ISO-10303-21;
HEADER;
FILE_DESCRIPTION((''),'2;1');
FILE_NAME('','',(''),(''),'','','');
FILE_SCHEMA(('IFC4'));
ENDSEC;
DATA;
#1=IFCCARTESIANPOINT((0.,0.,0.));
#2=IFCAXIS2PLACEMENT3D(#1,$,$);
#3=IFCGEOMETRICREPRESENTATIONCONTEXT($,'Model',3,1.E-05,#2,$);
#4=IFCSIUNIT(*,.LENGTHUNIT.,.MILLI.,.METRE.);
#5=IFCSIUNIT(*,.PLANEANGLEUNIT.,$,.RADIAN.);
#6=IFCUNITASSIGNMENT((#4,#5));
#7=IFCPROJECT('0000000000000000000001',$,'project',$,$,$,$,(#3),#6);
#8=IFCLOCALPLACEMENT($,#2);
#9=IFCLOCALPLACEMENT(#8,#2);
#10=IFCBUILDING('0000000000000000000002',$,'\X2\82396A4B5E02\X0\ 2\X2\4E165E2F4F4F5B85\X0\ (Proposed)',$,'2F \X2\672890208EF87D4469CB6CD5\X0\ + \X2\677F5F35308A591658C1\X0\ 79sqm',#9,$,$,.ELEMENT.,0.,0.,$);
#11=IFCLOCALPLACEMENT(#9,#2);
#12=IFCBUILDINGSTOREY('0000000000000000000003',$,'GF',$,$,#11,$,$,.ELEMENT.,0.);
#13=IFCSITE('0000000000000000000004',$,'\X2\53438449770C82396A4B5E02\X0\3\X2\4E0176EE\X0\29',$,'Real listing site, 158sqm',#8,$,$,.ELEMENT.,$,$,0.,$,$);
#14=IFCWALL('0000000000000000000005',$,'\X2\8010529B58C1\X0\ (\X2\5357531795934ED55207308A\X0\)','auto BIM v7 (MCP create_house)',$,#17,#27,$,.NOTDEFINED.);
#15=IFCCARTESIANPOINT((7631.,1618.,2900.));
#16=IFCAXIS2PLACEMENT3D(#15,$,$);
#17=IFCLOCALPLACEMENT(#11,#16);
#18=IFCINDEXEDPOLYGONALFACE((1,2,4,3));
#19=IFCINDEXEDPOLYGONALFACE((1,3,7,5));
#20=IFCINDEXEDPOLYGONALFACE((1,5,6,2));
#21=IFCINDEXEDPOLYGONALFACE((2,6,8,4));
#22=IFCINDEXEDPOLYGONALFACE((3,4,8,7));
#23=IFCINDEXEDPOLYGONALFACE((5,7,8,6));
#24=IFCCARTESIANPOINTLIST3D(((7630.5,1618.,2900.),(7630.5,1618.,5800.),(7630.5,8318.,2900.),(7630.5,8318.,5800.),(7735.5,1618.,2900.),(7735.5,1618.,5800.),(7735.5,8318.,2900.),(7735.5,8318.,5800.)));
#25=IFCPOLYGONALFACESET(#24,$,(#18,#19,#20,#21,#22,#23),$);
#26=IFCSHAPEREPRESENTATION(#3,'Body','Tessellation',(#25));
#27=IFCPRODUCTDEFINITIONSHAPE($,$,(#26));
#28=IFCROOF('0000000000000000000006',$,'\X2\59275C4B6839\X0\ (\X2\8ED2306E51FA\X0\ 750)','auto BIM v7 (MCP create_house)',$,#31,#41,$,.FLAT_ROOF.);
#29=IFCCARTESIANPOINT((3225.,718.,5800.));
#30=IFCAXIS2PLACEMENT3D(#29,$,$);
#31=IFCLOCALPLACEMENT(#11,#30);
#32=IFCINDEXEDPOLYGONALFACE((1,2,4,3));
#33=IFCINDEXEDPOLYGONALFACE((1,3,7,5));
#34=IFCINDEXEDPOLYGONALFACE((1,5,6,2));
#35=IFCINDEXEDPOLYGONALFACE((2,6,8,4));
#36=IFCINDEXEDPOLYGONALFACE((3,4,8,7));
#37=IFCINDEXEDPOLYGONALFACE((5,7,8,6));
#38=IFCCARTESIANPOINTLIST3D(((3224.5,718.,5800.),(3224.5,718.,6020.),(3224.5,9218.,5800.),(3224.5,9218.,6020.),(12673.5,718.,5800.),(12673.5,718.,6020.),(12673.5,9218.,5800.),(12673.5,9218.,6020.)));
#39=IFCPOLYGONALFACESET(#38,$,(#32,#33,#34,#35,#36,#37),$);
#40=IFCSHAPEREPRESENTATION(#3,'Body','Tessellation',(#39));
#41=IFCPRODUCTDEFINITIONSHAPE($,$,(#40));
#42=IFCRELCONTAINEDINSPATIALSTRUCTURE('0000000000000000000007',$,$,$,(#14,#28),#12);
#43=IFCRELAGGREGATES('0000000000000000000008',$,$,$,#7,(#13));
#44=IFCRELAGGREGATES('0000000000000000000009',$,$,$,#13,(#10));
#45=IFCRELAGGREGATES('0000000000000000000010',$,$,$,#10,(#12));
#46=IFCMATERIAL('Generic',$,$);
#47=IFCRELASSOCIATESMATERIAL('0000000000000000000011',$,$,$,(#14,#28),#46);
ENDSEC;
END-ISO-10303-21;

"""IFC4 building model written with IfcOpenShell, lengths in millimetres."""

from ifc_helpers import new_model, si_unit, frame, frame_2d, origin, place, context, project, spatial, rectangle, extrude, material, element, save


model = new_model("IFC4")

# Units and contexts
model_context = context("Model", 3, precision=1e-05, world=origin())
ifc_project = project(units=[si_unit("LENGTHUNIT", "METRE", prefix="MILLI"), si_unit("PLANEANGLEUNIT", "RADIAN")], contexts=[model_context])

# Site, building, storey
site_placement = place(None, origin())
site = spatial("IfcSite", under=ifc_project, at=site_placement, Name="千葉県船橋市3丁目29", ObjectType="Real listing site, 158sqm", CompositionType="ELEMENT", RefElevation=0.0)
building_placement = place(site_placement, origin())
building = spatial("IfcBuilding", under=site, at=building_placement, Name="船橋市 2世帯住宅 (Proposed)", ObjectType="2F 木造軸組構法 + 板張り外壁 79sqm", CompositionType="ELEMENT", ElevationOfRefHeight=0.0, ElevationOfTerrain=0.0)
storey_placement = place(building_placement, origin())
storey = spatial("IfcBuildingStorey", under=building, at=storey_placement, Name="GF", CompositionType="ELEMENT", Elevation=0.0)

# Shared definitions
ifc_material = material(Name="Generic")

# Wall
wall_1_placement = place(storey_placement, frame((7631.0, 1618.0, 2900.0)))
element("IfcWall", 1, at=wall_1_placement, inside=storey, material=ifc_material, Name="耐力壁 (南北間仕切り)", Description="auto BIM v7 (MCP create_house)", PredefinedType="NOTDEFINED", context=model_context, shape_type="SweptSolid", body=[
    extrude(rectangle(XDim=105.0, YDim=6700.0, at=frame_2d((52.0, 3350.0))), frame((7631.0, 1618.0, 2900.0)), (0.0, 0.0, 1.0), 2900.0),
])

# Roof
roof_placement = place(storey_placement, frame((3225.0, 718.0, 5800.0)))
element("IfcRoof", 2, at=roof_placement, inside=storey, material=ifc_material, Name="大屋根 (軒の出 750)", Description="auto BIM v7 (MCP create_house)", PredefinedType="FLAT_ROOF", context=model_context, shape_type="SweptSolid", body=[
    extrude(rectangle(XDim=9449.0, YDim=8500.0, at=frame_2d((4724.0, 4250.0))), frame((3225.0, 718.0, 5800.0)), (0.0, 0.0, 1.0), 220.0),
])

save(model, "model.ifc")
